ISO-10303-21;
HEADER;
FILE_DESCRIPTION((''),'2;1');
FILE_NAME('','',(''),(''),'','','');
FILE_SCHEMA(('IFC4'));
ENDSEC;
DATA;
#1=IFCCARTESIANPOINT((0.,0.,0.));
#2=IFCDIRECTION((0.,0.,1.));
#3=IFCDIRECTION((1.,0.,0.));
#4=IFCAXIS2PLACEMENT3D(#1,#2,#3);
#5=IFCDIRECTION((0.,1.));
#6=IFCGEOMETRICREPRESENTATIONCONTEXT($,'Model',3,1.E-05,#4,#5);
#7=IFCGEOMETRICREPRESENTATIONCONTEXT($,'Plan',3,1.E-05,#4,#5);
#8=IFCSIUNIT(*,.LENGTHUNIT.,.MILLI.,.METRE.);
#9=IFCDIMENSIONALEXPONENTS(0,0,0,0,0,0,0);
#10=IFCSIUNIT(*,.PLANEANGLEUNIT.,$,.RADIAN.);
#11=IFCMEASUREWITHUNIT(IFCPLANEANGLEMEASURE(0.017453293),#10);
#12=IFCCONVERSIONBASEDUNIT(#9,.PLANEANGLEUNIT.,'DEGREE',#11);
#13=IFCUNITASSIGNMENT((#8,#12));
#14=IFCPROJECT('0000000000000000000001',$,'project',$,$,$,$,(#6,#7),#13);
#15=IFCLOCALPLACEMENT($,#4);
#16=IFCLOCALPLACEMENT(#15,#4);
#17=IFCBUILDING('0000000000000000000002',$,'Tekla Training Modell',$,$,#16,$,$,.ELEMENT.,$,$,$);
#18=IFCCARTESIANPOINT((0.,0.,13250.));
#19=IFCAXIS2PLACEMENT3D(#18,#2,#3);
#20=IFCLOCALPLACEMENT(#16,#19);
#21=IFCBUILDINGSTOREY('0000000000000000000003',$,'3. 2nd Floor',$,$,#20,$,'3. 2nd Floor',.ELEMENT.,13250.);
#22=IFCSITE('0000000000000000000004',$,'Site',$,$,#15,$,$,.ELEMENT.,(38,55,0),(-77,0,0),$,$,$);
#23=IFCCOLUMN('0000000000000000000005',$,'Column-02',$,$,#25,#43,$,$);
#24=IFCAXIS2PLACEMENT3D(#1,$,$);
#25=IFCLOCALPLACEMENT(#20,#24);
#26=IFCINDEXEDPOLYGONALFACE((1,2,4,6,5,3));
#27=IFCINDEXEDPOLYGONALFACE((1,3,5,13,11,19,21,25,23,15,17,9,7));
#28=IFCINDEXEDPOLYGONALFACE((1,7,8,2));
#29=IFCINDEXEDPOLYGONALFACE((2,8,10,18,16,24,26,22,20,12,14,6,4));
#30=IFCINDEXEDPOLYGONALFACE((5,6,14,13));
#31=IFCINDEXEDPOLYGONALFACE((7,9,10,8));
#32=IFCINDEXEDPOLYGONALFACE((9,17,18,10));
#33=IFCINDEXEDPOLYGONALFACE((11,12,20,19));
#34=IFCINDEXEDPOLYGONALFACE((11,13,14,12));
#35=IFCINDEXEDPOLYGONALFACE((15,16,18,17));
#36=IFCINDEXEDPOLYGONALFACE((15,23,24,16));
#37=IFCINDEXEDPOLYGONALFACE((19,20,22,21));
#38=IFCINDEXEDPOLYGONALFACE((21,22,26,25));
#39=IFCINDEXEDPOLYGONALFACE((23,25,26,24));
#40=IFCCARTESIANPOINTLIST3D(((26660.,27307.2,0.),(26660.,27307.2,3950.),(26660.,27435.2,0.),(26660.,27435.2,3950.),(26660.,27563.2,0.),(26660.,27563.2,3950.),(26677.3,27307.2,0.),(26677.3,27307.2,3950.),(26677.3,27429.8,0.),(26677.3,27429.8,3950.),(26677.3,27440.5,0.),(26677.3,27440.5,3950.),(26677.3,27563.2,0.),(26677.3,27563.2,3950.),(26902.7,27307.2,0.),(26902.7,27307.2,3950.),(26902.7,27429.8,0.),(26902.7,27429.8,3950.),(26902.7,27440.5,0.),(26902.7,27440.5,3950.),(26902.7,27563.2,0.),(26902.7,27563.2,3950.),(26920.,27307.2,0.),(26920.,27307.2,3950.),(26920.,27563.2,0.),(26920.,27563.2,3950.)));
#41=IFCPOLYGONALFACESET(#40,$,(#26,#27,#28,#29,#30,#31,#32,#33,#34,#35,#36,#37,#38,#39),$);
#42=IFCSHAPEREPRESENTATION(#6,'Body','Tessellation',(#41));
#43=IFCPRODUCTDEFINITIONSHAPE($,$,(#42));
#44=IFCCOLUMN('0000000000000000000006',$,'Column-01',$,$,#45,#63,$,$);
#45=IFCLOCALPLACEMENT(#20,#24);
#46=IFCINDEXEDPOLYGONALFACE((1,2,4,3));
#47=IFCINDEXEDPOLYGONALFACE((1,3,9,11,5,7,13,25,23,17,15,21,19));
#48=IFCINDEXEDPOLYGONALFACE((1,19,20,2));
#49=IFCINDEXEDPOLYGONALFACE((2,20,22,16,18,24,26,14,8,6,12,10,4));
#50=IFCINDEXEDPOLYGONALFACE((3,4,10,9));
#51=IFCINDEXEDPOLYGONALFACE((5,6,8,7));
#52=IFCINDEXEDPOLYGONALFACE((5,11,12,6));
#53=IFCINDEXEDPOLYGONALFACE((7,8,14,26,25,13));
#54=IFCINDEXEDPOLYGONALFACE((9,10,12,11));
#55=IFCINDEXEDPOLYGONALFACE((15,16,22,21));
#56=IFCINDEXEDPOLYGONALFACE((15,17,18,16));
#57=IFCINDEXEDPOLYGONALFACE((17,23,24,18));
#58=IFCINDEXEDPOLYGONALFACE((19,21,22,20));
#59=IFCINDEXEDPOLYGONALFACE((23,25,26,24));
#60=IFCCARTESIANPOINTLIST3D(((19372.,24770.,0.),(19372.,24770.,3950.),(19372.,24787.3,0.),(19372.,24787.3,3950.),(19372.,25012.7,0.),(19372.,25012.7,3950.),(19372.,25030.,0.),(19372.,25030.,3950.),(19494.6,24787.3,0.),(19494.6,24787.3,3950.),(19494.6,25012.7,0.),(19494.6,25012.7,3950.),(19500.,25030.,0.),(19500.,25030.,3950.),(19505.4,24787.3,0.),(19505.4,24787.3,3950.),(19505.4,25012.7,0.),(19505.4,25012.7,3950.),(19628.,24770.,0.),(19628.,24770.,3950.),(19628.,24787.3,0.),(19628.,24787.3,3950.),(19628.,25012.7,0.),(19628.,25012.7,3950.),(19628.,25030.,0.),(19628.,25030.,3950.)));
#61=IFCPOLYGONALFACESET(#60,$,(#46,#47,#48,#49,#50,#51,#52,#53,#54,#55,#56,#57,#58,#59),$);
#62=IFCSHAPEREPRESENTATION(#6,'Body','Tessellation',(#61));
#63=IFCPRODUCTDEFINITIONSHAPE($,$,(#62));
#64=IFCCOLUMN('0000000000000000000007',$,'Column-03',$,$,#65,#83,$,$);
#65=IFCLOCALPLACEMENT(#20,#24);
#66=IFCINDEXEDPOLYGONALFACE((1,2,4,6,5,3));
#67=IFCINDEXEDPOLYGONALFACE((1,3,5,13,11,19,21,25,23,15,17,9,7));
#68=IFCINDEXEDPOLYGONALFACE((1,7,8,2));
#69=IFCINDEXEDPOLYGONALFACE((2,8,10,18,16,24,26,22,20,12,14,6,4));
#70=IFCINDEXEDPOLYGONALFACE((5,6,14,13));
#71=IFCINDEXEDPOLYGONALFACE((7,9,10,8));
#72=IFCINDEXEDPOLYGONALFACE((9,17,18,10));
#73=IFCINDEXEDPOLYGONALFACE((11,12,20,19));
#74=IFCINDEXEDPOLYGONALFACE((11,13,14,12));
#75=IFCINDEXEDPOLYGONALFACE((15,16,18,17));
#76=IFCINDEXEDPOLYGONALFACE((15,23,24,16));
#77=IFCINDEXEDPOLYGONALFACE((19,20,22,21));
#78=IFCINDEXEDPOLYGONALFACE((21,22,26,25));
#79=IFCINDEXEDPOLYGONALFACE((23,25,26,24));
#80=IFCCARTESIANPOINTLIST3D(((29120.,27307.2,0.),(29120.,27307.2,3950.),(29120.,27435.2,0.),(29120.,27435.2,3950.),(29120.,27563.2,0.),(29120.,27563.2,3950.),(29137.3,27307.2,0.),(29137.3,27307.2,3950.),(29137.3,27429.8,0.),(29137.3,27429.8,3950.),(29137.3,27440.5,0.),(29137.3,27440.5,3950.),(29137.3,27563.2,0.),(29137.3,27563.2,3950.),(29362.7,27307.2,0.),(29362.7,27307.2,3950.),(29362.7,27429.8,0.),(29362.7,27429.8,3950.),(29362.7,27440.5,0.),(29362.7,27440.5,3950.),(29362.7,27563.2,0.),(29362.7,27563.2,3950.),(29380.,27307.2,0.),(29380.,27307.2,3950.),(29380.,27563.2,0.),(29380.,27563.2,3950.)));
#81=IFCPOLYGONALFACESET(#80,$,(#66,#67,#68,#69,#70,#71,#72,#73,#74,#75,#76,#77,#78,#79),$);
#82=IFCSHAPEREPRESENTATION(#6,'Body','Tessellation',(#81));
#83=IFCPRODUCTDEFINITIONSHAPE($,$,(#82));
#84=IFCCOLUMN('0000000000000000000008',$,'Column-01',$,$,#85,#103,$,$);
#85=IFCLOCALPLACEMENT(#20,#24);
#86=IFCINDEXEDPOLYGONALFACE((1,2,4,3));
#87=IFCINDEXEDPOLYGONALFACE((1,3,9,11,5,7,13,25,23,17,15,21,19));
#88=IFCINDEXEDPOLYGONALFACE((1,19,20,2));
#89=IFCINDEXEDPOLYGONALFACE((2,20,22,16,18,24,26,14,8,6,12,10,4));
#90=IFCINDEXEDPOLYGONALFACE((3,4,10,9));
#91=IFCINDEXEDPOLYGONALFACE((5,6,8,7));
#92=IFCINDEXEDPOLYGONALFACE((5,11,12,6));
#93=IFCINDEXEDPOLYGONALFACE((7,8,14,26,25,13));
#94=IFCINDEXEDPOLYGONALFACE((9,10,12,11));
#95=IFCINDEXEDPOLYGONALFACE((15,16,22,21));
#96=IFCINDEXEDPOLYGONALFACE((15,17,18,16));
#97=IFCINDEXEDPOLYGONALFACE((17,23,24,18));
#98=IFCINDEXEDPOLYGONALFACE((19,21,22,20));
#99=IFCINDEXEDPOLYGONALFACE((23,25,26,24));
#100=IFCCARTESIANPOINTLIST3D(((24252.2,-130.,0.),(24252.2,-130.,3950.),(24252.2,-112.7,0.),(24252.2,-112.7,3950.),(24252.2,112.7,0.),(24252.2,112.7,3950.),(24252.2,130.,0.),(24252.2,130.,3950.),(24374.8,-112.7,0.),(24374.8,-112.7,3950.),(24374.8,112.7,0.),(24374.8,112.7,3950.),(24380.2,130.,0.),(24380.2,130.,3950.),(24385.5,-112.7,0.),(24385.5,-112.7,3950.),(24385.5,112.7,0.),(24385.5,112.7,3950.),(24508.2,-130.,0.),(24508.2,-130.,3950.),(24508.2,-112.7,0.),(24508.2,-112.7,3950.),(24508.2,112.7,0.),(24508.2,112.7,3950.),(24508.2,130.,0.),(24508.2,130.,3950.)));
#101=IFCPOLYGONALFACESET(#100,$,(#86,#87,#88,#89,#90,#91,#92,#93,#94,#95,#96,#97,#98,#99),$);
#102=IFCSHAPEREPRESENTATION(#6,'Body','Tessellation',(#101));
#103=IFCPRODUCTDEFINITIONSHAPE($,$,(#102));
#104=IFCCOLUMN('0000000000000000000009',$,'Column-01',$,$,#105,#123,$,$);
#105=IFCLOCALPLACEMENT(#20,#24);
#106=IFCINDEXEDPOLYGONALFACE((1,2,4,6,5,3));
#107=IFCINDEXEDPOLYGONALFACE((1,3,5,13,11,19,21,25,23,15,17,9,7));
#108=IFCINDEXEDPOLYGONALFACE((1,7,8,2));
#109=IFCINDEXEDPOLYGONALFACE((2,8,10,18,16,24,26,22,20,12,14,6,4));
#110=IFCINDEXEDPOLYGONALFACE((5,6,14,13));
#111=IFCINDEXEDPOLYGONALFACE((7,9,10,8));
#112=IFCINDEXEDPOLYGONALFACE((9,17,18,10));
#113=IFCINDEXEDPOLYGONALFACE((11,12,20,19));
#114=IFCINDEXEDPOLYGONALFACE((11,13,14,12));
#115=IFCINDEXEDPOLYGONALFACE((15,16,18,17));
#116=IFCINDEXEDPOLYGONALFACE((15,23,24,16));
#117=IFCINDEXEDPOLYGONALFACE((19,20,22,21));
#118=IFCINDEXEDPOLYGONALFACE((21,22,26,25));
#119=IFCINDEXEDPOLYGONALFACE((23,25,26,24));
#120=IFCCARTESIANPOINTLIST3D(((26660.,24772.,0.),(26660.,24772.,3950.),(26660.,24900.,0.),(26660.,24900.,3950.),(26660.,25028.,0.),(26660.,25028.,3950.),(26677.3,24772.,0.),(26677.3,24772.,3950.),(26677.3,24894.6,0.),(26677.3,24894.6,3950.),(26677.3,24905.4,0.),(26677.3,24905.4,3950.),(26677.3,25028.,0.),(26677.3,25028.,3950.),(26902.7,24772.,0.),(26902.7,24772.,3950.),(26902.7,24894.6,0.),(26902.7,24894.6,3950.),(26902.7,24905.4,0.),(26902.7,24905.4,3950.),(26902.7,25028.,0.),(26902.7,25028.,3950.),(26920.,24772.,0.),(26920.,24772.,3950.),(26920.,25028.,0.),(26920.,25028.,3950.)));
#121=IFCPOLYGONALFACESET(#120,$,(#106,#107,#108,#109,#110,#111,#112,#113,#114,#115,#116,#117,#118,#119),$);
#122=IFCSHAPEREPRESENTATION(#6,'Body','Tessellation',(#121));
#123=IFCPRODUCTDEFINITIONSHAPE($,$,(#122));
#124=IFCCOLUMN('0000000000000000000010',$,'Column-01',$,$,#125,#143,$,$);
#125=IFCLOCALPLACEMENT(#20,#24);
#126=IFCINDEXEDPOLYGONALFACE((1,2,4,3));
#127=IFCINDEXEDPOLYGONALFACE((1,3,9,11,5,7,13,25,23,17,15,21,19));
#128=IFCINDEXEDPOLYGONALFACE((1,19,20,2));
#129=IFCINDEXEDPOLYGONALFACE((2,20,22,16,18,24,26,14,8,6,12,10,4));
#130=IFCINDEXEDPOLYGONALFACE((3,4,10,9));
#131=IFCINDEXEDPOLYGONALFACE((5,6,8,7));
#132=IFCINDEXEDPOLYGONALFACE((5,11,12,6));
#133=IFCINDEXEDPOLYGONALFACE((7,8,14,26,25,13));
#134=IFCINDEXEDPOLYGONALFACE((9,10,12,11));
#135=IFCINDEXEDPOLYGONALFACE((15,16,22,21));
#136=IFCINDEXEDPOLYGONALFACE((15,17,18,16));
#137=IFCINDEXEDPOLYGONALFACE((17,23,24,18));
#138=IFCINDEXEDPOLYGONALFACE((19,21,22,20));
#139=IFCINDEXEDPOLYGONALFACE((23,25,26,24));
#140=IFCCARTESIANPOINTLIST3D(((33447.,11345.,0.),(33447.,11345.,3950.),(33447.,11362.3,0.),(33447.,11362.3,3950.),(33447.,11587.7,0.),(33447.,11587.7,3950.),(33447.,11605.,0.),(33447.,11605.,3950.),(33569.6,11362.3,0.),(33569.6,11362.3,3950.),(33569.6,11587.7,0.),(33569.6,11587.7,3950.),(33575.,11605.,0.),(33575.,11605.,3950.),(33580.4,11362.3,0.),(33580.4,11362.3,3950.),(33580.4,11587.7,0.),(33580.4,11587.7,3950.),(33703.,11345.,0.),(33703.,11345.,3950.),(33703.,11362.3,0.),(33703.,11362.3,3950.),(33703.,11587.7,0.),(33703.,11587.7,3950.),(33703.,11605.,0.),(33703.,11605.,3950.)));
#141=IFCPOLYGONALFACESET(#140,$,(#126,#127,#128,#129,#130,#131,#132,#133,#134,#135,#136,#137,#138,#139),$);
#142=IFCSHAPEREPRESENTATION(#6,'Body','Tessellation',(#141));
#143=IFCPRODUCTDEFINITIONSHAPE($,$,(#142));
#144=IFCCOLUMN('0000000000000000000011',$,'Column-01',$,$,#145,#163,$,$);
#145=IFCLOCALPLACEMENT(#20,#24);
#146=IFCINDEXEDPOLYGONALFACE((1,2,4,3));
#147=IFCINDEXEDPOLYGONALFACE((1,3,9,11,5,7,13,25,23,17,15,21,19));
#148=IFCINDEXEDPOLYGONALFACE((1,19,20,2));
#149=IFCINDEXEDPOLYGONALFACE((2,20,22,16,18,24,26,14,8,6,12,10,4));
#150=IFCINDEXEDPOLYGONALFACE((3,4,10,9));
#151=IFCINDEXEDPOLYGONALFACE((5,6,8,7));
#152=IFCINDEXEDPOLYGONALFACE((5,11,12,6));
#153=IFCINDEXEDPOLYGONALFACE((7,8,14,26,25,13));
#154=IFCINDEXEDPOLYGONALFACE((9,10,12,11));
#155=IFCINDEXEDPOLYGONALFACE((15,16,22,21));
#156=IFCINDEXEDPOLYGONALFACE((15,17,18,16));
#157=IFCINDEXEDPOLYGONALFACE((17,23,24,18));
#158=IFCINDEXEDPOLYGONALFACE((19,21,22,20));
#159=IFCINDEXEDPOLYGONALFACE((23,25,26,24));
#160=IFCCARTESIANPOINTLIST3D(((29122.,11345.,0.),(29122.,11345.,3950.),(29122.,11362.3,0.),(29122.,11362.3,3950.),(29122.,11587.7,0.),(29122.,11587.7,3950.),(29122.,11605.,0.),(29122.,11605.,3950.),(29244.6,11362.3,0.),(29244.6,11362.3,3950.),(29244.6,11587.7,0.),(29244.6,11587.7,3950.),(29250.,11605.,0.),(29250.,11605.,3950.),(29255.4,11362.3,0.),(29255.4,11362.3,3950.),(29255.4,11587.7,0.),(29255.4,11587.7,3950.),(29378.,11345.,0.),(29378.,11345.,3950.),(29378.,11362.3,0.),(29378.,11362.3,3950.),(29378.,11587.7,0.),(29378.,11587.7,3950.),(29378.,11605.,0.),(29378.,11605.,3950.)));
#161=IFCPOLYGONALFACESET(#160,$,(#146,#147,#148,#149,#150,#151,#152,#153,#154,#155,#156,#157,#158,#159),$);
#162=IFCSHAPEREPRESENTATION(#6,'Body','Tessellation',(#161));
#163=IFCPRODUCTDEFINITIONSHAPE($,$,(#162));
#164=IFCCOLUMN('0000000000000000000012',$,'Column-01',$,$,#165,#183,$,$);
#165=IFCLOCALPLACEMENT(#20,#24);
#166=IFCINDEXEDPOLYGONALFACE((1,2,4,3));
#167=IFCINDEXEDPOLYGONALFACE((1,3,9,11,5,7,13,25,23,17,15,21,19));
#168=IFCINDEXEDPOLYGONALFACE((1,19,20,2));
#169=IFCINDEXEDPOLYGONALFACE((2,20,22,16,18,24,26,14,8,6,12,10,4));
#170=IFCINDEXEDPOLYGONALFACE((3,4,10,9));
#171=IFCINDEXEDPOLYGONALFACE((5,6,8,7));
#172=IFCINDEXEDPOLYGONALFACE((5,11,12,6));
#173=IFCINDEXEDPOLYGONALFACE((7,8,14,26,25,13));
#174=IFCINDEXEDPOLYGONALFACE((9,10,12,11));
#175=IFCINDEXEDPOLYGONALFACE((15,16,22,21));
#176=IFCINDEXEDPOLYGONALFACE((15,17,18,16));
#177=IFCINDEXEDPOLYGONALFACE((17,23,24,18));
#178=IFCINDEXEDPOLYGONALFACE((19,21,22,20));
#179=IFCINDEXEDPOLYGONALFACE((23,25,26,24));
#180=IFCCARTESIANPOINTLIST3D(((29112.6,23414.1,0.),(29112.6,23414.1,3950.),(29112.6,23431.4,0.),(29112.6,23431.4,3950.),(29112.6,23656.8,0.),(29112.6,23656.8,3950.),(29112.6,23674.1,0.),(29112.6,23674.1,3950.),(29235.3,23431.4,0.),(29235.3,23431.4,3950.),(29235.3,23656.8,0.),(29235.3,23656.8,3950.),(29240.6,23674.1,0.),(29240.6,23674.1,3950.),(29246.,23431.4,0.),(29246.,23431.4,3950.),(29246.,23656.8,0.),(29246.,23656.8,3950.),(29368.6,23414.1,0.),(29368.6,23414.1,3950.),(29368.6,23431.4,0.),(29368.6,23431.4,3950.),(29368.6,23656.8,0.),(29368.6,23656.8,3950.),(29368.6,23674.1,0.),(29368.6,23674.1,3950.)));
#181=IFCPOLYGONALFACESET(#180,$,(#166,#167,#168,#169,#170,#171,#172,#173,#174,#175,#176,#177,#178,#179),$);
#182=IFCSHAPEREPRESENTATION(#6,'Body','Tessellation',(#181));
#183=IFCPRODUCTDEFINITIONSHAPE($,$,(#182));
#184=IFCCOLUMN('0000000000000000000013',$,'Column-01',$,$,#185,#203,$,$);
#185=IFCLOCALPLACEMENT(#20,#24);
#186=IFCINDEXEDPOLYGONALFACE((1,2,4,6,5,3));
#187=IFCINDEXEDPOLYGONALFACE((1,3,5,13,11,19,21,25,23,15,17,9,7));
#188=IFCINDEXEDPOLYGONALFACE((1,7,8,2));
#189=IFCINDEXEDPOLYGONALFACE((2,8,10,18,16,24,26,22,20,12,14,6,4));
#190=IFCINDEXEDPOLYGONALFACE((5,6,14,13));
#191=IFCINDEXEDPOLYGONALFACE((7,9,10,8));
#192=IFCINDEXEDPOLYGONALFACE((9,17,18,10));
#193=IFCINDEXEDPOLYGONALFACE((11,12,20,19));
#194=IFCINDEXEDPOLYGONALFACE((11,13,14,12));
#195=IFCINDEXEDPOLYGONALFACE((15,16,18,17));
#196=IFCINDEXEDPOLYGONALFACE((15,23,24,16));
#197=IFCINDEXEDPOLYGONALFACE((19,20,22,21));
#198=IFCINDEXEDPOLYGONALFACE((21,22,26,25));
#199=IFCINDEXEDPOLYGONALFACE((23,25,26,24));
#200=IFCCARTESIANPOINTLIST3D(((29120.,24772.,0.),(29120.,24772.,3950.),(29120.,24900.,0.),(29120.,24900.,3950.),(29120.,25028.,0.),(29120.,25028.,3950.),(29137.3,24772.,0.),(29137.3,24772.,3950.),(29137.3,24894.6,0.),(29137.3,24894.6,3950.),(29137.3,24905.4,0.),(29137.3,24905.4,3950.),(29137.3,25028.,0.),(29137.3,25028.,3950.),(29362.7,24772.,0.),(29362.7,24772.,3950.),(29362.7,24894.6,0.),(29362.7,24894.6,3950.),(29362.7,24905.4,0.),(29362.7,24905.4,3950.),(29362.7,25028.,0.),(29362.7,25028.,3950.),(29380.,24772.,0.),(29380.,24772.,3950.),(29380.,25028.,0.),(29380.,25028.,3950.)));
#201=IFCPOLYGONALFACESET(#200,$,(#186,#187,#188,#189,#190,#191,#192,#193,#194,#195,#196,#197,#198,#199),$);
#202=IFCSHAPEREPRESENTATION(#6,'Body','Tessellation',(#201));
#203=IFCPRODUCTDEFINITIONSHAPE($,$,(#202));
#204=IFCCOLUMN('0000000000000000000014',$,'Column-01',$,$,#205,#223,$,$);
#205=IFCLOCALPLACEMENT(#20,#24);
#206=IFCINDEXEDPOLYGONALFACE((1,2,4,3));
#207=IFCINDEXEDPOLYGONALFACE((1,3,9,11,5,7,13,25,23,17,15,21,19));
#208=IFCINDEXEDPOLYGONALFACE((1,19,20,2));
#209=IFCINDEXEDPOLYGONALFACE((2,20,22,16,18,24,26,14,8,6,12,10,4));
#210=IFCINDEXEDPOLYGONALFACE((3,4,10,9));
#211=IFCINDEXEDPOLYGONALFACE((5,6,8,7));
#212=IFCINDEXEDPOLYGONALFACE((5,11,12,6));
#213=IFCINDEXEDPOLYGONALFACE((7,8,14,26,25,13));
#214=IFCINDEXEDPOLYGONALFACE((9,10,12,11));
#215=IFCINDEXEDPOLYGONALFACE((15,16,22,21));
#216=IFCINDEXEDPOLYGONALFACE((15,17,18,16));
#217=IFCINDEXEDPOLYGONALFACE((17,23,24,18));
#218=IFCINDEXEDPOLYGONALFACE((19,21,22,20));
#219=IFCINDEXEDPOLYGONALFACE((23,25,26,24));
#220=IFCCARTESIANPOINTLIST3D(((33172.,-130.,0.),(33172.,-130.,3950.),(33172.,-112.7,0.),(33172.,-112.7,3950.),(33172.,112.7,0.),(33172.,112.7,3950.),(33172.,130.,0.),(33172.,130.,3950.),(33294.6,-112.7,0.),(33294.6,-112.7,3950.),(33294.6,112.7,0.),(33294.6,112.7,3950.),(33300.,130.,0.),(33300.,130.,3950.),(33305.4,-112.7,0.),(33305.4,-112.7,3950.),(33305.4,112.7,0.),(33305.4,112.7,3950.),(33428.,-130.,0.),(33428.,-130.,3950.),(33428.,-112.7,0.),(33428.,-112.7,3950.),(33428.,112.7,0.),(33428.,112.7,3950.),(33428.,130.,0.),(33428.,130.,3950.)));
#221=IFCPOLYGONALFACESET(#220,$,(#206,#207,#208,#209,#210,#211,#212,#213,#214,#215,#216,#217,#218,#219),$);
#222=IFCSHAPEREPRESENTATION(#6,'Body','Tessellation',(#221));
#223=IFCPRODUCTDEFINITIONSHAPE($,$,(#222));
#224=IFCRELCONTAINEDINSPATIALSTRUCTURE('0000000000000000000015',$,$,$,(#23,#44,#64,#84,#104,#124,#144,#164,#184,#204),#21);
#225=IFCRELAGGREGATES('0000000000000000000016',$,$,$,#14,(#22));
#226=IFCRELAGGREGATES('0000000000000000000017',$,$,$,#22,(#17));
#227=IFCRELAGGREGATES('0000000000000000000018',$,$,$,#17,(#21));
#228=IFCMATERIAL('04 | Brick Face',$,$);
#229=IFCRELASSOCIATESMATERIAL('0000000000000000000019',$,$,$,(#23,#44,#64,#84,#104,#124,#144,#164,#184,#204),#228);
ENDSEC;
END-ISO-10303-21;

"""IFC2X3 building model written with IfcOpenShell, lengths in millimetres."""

from ifc_helpers import new_model, entity, si_unit, converted_unit, direction, frame, origin_with_axes, place, context, project, spatial, polyline, outline, extrude, material, element, save


model = new_model("IFC2X3")

# Units and contexts
model_context = context("Model", 3, precision=1e-05, world=origin_with_axes(), true_north=direction((0.0, 1.0)))
plan_context = context("Plan", 3, precision=1e-05, world=origin_with_axes(), true_north=direction((0.0, 1.0)))
ifc_project = project(units=[si_unit("LENGTHUNIT", "METRE", prefix="MILLI"), converted_unit("PLANEANGLEUNIT", "DEGREE", entity("IfcPlaneAngleMeasure", 0.017453293), si_unit("PLANEANGLEUNIT", "RADIAN"), dimensions=[0, 0, 0, 0, 0, 0, 0])], contexts=[model_context, plan_context])

# Site, building, storey
site_placement = place(None, origin_with_axes())
site = spatial("IfcSite", under=ifc_project, at=site_placement, Name="Site", CompositionType="ELEMENT", RefLatitude=(38, 55, 0), RefLongitude=(-77, 0, 0))
building_placement = place(site_placement, origin_with_axes())
building = spatial("IfcBuilding", under=site, at=building_placement, Name="Tekla Training Modell", CompositionType="ELEMENT")
storey_placement = place(building_placement, frame((0.0, 0.0, 13250.0), z_axis=(0.0, 0.0, 1.0), x_axis=(1.0, 0.0, 0.0)))
storey = spatial("IfcBuildingStorey", under=building, at=storey_placement, Name="3. 2nd Floor", LongName="3. 2nd Floor", CompositionType="ELEMENT", Elevation=13250.0)

# Columns
ifc_material_1 = material(Name="04 | Brick Face")
for number, where, z_axis, x_axis, name in (
    (1, (26790.0, 27435.2, 0.0), (0.0, 0.0, 1.0), (0.0, 1.0, 0.0), "Column-02"),
    (2, (19500.0, 24900.0, 0.0), (0.0, 0.0, 1.0), (1.0, 0.0, 0.0), "Column-01"),
    (3, (29250.0, 27435.2, 0.0), (0.0, 0.0, 1.0), (0.0, 1.0, 0.0), "Column-03"),
    (4, (24380.2, 0.0, 0.0), (0.0, 0.0, 1.0), (1.0, 0.0, 0.0), "Column-01"),
    (5, (26790.0, 24900.0, 0.0), (0.0, 0.0, 1.0), (0.0, 1.0, 0.0), "Column-01"),
    (6, (33575.0, 11475.0, 0.0), (0.0, 0.0, 1.0), (1.0, 0.0, 0.0), "Column-01"),
    (7, (29250.0, 11475.0, 0.0), (0.0, 0.0, 1.0), (1.0, 0.0, 0.0), "Column-01"),
    (8, (29240.6, 23544.1, 0.0), (0.0, 0.0, 1.0), (1.0, 0.0, 0.0), "Column-01"),
    (9, (29250.0, 24900.0, 0.0), (0.0, 0.0, 1.0), (0.0, 1.0, 0.0), "Column-01"),
    (10, (33300.0, 0.0, 0.0), (0.0, 0.0, 1.0), (1.0, 0.0, 0.0), "Column-01"),
):
    element("IfcColumn", number, at=place(storey_placement, frame(where, z_axis=z_axis, x_axis=x_axis)), inside=storey, material=ifc_material_1, Name=name, context=model_context, shape_type="SweptSolid", body=[
        extrude(outline(polyline([(0.0, 130.0), (-128.0, 130.0), (-128.0, 112.7), (-5.3, 112.7), (-5.3, -112.7), (-128.0, -112.7), (-128.0, -130.0), (128.0, -130.0), (128.0, -112.7), (5.3, -112.7), (5.3, 112.7), (128.0, 112.7), (128.0, 130.0), (0.0, 130.0)])), origin_with_axes(), (0.0, 0.0, 1.0), 3950.0),
    ])

save(model, "model.ifc")
